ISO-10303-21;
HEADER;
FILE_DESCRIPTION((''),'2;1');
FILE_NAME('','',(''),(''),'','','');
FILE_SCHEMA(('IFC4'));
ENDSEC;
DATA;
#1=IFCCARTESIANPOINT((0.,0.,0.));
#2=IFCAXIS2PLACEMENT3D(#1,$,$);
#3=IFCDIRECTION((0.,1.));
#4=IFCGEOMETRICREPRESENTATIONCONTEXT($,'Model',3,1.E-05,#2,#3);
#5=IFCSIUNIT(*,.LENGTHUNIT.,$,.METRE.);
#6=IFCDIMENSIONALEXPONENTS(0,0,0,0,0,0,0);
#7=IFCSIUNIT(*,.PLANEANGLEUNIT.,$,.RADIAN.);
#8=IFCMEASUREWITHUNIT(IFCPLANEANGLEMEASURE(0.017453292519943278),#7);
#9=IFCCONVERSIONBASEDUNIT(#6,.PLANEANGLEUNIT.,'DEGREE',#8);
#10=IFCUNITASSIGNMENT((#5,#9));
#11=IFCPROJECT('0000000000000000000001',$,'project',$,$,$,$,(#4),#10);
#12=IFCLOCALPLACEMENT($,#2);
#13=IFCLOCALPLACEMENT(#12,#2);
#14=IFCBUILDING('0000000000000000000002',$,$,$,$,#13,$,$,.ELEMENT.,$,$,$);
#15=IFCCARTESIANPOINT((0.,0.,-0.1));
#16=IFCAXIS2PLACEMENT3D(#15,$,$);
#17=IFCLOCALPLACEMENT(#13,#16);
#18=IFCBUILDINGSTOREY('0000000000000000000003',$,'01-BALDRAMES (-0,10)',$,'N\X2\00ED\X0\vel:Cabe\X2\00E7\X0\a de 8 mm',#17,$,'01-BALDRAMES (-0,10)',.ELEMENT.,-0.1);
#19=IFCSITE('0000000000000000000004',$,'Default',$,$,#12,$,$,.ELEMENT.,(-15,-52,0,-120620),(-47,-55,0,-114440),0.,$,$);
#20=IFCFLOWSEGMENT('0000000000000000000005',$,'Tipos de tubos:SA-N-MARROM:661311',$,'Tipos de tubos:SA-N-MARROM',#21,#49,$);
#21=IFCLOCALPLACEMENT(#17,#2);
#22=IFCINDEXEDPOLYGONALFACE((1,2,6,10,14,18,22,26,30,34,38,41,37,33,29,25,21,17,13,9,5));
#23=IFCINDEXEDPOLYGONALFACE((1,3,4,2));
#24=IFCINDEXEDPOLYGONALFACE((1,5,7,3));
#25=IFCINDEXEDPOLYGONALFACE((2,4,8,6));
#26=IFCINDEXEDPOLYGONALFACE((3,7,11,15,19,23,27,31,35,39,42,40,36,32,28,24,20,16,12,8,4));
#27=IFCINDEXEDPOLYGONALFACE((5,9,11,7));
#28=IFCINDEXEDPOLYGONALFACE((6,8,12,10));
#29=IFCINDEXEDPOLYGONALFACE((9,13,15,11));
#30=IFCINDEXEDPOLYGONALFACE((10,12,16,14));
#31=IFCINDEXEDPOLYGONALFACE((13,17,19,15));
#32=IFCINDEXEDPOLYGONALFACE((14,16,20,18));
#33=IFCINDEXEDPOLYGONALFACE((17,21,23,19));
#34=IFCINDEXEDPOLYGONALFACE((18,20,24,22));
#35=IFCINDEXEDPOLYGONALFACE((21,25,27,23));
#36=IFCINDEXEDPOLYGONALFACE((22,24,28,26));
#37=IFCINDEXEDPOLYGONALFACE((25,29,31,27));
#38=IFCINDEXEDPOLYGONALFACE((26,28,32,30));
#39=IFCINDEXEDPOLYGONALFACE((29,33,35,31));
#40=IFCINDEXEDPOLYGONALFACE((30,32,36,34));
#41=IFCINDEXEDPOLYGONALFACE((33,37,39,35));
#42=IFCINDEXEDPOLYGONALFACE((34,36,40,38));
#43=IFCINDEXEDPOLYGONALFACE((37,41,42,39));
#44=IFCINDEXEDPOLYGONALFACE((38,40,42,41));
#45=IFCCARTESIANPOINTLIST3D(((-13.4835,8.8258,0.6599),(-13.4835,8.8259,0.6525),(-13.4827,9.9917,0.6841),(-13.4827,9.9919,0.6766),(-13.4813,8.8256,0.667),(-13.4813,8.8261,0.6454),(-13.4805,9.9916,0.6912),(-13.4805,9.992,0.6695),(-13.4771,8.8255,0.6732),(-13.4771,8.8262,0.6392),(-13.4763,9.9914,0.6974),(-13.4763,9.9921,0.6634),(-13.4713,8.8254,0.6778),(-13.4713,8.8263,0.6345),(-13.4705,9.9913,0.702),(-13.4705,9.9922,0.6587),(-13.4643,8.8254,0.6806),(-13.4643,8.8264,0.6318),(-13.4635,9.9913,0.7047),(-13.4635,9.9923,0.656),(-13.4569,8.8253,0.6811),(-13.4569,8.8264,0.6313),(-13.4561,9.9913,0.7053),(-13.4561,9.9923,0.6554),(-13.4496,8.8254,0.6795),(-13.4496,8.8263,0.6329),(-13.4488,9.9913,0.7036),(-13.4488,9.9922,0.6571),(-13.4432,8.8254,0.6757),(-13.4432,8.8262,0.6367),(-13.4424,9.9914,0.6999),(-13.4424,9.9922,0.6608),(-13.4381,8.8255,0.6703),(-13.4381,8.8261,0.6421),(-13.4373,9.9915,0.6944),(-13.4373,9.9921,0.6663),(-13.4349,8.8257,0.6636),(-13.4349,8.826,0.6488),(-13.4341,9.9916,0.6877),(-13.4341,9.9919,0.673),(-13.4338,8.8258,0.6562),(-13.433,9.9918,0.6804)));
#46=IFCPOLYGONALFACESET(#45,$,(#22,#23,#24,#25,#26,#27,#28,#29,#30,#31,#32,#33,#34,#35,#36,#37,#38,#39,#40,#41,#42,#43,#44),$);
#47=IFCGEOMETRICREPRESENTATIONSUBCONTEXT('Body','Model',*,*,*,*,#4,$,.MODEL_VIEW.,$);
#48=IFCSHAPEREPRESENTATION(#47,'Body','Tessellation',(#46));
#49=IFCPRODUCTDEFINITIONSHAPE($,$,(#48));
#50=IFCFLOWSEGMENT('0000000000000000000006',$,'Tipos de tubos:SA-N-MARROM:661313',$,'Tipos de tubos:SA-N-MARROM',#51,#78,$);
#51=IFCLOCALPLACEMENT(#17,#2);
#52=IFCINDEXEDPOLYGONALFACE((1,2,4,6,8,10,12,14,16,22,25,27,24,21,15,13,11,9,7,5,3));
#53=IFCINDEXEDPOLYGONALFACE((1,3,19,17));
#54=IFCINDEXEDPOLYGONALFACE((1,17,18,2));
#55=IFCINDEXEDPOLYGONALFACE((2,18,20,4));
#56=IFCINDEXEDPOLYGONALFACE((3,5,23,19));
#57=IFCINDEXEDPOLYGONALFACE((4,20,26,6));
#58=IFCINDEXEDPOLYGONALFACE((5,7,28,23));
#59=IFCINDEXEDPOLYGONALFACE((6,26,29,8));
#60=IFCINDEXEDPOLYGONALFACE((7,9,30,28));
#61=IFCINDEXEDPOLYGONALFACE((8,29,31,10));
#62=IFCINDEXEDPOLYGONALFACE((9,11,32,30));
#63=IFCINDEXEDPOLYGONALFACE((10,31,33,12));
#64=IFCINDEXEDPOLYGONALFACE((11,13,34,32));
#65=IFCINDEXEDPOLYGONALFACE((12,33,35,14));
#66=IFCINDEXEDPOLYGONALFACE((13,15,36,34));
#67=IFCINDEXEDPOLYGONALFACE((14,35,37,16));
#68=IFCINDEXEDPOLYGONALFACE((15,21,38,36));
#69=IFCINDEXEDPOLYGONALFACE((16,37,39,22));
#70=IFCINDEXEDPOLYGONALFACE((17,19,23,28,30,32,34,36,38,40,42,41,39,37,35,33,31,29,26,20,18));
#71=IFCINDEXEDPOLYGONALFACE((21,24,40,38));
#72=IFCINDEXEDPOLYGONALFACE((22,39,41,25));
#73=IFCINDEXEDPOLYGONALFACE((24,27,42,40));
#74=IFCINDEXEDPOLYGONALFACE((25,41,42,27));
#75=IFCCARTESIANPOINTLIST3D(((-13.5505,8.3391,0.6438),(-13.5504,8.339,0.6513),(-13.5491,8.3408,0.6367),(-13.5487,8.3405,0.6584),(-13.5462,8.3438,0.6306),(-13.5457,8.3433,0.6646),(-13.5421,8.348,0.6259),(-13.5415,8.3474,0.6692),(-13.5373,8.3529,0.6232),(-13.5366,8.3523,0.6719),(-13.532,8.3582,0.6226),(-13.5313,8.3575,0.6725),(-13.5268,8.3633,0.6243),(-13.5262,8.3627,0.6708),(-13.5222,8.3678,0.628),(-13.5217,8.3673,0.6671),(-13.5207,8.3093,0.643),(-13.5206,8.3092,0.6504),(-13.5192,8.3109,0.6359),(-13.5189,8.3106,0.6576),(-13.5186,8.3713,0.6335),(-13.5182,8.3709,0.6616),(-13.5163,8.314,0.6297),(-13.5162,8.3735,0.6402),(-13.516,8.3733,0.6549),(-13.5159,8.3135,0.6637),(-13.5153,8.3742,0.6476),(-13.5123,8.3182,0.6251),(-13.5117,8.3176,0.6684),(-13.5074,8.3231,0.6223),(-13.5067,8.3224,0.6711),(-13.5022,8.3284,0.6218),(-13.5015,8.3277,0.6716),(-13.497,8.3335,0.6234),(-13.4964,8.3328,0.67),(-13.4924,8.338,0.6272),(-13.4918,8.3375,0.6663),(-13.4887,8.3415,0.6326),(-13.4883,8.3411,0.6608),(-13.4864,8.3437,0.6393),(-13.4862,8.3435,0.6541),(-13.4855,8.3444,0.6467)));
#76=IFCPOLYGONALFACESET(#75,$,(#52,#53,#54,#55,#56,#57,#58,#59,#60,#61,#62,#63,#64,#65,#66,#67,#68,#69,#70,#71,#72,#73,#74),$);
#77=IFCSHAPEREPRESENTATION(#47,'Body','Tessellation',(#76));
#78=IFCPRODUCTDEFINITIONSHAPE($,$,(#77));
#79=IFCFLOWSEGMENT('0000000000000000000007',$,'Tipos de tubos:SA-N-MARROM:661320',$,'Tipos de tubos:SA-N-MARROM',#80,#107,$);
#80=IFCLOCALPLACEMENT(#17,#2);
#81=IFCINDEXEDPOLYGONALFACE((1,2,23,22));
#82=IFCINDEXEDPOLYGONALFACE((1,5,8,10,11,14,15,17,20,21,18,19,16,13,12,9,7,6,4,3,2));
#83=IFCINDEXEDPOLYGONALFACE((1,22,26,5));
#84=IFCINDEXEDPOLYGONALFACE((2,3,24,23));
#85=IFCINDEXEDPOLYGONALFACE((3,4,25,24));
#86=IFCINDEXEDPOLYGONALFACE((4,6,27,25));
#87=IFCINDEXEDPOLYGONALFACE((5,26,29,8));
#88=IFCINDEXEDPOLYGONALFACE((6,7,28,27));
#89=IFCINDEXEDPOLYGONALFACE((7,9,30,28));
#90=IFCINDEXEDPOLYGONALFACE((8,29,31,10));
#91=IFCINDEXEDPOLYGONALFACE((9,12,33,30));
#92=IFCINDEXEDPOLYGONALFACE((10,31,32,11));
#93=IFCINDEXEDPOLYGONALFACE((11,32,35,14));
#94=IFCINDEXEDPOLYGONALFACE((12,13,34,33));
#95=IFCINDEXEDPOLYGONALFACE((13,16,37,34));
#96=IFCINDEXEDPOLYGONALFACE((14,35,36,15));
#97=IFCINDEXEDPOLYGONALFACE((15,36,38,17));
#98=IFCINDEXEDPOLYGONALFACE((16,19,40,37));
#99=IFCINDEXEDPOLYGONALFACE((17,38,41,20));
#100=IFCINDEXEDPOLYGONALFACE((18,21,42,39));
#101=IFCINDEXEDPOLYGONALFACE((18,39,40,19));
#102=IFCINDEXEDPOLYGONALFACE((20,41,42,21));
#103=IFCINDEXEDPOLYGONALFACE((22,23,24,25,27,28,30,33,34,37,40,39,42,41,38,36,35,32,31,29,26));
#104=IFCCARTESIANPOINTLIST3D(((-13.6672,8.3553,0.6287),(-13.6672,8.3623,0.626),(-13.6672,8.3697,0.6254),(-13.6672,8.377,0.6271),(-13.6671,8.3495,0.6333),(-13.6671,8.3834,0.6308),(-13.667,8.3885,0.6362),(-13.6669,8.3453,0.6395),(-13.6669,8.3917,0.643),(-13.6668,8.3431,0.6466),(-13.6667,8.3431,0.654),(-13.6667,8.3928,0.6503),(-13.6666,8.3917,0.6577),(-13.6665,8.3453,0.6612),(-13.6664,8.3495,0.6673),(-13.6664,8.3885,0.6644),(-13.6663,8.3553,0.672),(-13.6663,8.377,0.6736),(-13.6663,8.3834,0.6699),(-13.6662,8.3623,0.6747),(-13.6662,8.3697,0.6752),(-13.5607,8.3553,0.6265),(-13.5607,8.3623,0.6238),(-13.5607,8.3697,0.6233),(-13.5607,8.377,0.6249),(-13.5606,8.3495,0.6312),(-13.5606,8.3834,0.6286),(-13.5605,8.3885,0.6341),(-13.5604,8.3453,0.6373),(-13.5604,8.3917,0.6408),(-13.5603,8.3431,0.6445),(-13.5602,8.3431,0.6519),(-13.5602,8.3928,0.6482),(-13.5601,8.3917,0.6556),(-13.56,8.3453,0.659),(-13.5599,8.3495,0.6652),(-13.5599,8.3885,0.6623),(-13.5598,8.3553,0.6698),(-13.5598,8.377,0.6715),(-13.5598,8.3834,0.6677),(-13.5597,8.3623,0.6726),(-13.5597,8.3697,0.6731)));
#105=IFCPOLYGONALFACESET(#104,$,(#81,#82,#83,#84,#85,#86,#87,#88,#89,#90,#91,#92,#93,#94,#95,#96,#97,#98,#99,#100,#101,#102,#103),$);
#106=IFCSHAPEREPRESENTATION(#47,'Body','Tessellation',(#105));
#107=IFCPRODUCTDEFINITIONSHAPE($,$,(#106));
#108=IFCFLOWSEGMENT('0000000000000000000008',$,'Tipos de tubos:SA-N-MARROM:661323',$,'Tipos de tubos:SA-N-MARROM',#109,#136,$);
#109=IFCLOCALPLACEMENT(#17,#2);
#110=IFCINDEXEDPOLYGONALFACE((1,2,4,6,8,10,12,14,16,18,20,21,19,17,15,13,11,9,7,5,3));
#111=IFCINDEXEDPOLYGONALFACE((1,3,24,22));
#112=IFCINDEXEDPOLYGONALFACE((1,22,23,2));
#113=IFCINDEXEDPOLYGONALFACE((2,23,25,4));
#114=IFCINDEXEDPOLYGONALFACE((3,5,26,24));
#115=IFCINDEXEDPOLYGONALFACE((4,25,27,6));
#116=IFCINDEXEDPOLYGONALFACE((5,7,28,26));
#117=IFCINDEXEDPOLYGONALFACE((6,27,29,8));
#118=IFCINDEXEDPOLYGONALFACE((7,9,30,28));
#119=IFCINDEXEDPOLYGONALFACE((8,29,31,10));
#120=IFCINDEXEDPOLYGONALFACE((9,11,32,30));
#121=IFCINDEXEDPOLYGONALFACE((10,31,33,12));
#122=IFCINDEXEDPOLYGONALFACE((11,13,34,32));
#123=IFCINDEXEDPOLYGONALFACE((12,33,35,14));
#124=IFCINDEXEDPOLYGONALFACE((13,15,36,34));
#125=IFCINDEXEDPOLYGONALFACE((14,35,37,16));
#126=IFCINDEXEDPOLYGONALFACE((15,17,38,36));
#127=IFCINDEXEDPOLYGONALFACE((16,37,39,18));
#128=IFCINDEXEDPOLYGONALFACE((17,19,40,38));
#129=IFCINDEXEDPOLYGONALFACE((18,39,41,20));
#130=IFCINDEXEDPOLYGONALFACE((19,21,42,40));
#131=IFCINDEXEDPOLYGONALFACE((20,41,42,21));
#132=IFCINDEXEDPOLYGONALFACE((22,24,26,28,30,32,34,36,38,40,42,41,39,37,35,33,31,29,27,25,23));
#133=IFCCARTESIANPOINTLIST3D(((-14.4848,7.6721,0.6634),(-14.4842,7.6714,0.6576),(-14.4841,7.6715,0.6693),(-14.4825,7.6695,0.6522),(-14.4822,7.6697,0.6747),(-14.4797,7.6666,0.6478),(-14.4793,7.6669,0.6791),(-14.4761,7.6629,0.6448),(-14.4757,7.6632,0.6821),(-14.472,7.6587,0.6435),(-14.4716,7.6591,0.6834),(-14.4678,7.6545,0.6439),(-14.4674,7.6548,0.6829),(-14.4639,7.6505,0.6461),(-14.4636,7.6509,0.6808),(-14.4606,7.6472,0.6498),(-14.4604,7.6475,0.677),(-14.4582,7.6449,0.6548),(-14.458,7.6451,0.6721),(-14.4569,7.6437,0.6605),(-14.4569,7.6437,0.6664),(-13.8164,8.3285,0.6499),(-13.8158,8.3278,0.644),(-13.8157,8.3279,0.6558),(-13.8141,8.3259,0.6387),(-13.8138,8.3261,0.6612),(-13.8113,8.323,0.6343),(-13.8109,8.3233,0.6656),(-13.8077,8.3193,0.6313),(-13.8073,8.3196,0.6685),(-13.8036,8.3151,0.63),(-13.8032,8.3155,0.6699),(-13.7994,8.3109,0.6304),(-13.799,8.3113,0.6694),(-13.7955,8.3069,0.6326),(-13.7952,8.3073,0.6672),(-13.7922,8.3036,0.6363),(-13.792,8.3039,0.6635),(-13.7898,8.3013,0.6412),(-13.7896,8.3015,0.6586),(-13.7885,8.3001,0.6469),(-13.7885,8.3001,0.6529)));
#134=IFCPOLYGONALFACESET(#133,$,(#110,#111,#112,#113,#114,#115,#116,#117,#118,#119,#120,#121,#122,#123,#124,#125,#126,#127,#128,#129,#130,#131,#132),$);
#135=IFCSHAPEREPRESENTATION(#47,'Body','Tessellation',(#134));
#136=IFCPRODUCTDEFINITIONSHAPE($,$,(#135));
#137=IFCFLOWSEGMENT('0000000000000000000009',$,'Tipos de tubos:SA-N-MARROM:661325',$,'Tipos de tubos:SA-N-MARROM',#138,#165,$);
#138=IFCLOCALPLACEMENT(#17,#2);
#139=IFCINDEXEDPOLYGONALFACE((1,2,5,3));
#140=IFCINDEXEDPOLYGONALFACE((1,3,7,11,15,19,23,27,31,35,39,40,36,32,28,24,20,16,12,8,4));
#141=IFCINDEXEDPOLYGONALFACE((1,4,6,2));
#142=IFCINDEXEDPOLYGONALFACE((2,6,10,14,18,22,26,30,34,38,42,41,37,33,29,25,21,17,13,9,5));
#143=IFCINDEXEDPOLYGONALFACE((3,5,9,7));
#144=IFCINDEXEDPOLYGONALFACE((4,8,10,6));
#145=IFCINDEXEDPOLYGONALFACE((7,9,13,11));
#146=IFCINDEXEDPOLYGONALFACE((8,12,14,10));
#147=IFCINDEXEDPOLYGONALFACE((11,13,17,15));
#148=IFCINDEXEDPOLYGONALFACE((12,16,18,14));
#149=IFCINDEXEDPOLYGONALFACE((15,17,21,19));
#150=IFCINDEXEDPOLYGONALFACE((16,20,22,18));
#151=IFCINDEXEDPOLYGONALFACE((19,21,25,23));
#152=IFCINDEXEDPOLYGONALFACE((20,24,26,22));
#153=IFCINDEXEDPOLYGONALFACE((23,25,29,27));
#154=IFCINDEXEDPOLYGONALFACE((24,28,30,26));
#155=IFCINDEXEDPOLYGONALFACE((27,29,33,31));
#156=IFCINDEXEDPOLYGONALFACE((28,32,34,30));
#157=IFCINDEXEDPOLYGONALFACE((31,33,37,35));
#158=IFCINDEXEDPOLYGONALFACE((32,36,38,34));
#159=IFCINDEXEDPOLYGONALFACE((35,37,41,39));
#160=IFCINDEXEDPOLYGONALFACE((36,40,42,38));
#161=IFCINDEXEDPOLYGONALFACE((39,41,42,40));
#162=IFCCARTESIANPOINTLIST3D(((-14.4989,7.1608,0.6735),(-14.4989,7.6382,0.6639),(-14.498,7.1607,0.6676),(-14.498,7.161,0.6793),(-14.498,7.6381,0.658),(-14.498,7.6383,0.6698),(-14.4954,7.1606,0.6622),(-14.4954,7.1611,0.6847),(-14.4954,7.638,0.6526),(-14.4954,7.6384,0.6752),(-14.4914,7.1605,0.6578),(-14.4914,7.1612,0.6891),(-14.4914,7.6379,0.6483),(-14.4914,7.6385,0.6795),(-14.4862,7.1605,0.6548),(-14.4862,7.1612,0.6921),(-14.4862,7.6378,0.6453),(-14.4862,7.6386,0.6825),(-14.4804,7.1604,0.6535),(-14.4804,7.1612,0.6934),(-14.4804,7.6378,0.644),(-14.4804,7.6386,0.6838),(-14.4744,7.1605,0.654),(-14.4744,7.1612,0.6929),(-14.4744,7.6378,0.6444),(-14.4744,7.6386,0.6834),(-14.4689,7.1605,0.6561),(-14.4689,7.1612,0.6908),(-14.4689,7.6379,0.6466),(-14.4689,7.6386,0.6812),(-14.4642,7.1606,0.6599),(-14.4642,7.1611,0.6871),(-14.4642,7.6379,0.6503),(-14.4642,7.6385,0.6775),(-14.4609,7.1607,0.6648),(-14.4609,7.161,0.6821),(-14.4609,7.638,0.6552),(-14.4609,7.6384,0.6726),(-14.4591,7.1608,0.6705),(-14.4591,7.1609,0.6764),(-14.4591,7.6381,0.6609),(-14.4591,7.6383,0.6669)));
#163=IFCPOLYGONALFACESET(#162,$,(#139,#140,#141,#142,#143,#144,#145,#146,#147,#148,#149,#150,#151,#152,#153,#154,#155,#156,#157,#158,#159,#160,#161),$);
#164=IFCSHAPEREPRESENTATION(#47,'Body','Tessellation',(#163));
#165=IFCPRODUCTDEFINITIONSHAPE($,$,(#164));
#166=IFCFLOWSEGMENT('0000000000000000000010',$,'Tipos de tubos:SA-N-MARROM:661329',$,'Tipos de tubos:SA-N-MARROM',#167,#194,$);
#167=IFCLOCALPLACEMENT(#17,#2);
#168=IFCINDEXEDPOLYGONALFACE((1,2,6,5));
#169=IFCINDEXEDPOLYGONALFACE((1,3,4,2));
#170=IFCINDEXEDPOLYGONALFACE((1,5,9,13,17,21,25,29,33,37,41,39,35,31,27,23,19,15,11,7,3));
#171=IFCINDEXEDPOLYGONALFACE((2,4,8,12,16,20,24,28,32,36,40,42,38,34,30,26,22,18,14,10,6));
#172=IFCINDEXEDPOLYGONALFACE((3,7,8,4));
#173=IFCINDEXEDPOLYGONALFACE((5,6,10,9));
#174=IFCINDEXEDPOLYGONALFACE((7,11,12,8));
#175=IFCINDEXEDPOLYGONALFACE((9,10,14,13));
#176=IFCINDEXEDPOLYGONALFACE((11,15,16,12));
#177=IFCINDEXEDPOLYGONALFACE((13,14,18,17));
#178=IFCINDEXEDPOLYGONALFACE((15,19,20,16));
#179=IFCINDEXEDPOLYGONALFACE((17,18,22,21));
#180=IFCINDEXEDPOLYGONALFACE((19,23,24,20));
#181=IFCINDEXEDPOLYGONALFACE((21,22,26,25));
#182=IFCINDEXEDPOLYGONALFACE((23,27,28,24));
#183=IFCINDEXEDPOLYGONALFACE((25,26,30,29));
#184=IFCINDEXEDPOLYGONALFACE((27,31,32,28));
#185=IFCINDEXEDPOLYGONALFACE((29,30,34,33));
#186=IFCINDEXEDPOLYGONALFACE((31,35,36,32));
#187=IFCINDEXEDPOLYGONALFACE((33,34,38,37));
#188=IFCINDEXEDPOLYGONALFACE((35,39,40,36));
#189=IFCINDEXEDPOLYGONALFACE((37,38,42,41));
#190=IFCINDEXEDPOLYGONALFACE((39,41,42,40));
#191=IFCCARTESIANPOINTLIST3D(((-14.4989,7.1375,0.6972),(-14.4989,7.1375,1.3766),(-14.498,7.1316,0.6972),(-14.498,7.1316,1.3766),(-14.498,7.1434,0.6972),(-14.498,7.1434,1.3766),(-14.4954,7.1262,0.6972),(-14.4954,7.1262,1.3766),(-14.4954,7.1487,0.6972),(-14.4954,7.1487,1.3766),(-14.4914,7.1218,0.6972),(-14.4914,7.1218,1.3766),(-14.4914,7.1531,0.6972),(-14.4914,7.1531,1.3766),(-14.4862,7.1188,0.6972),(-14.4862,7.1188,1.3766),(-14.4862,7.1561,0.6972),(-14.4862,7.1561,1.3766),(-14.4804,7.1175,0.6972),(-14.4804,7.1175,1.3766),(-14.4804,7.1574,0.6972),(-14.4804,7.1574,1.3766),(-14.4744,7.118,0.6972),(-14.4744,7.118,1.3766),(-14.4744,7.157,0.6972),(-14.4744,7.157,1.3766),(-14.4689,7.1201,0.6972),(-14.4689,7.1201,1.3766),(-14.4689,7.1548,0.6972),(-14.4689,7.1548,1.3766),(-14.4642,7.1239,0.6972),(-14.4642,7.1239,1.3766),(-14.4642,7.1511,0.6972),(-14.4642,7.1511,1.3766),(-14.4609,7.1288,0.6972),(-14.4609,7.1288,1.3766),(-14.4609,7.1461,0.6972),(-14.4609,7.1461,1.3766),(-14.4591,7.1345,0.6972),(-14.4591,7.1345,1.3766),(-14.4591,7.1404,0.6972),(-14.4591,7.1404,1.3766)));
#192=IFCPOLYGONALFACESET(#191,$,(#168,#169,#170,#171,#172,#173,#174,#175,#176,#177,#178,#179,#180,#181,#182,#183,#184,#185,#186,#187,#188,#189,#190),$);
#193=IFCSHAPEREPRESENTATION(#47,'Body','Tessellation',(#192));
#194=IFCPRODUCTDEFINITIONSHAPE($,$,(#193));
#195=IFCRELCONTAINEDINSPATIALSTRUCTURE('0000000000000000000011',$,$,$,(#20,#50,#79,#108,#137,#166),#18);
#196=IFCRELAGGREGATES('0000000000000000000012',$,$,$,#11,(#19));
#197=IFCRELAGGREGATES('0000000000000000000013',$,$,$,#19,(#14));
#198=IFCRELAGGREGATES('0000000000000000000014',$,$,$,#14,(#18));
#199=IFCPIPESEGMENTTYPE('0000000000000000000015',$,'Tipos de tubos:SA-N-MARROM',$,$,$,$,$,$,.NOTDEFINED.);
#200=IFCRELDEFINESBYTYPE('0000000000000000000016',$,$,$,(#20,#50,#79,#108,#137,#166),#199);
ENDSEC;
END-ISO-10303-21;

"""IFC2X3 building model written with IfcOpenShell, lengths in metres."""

from ifc_helpers import new_model, entity, si_unit, converted_unit, direction, frame, frame_2d, origin, origin_2d_with_axis, place, context, subcontext, project, spatial, circle, extrude, type_object, element, save


model = new_model("IFC2X3")

# Units and contexts
model_context = context("Model", 3, precision=1e-05, world=origin(), true_north=direction((0.0, 1.0)))
body_context = subcontext(model_context, "Body", "Model", "MODEL_VIEW")
ifc_project = project(units=[si_unit("LENGTHUNIT", "METRE"), converted_unit("PLANEANGLEUNIT", "DEGREE", entity("IfcPlaneAngleMeasure", 0.017453292519943278), si_unit("PLANEANGLEUNIT", "RADIAN"), dimensions=[0, 0, 0, 0, 0, 0, 0])], contexts=[model_context])

# Site, building, storey
site_placement = place(None, origin())
site = spatial("IfcSite", under=ifc_project, at=site_placement, Name="Default", CompositionType="ELEMENT", RefLatitude=(-15, -52, 0, -120620), RefLongitude=(-47, -55, 0, -114440), RefElevation=0.0)
building_placement = place(site_placement, origin())
building = spatial("IfcBuilding", under=site, at=building_placement, CompositionType="ELEMENT")
storey_placement = place(building_placement, frame((0.0, 0.0, -0.1)))
storey = spatial("IfcBuildingStorey", under=building, at=storey_placement, Name="01-BALDRAMES (-0,10)", ObjectType="Nível:Cabeça de 8 mm", LongName="01-BALDRAMES (-0,10)", CompositionType="ELEMENT", Elevation=-0.1)

# Flow segments
pipe_segment_type_1 = type_object("IfcPipeSegmentType", Name="Tipos de tubos:SA-N-MARROM", PredefinedType="NOTDEFINED")
flow_segment_1_placement = place(storey_placement, origin())
element("IfcFlowSegment", 1, at=flow_segment_1_placement, inside=storey, type_object=pipe_segment_type_1, Name="Tipos de tubos:SA-N-MARROM:661311", ObjectType="Tipos de tubos:SA-N-MARROM", context=body_context, shape_type="SweptSolid", body=[
    extrude(circle(Radius=0.025, at=origin_2d_with_axis()), frame((-13.4588, 8.8259, 0.6562), z_axis=(0.000685, 0.999785, 0.020718), x_axis=(1.0, -0.000685, 0.0)), (0.0, 0.0, 1.0), 1.1662),
])
flow_segment_2_placement = place(storey_placement, origin())
element("IfcFlowSegment", 2, at=flow_segment_2_placement, inside=storey, type_object=pipe_segment_type_1, Name="Tipos de tubos:SA-N-MARROM:661313", ObjectType="Tipos de tubos:SA-N-MARROM", context=body_context, shape_type="SweptSolid", body=[
    extrude(circle(Radius=0.025, at=frame_2d((0.0, 0.0), x_axis=(1.0, 0.0))), frame((-13.5031, 8.3267, 0.6467), z_axis=(-0.706966, 0.706965, 0.019996), x_axis=(0.707106, 0.707107, 0.0)), (0.0, 0.0, 1.0), 0.0422),
])
flow_segment_3_placement = place(storey_placement, origin())
element("IfcFlowSegment", 3, at=flow_segment_3_placement, inside=storey, type_object=pipe_segment_type_1, Name="Tipos de tubos:SA-N-MARROM:661320", ObjectType="Tipos de tubos:SA-N-MARROM", context=body_context, shape_type="SweptSolid", body=[
    extrude(circle(Radius=0.025, at=frame_2d((0.0, 0.0), x_axis=(1.0, 0.0))), frame((-13.5602, 8.3678, 0.6482), z_axis=(-0.9998, -0.000001, 0.019996), x_axis=(-0.000001, 1.0, 0.0)), (0.0, 0.0, 1.0), 0.1065),
])
flow_segment_4_placement = place(storey_placement, origin())
element("IfcFlowSegment", 4, at=flow_segment_4_placement, inside=storey, type_object=pipe_segment_type_1, Name="Tipos de tubos:SA-N-MARROM:661323", ObjectType="Tipos de tubos:SA-N-MARROM", context=body_context, shape_type="SweptSolid", body=[
    extrude(circle(Radius=0.02, at=frame_2d((0.0, 0.0), x_axis=(1.0, 0.0))), frame((-13.8024, 8.3142, 0.6499), z_axis=(-0.713408, -0.700601, 0.014439), x_axis=(-0.700674, 0.713482, 0.0)), (0.0, 0.0, 1.0), 0.9369),
])
flow_segment_5_placement = place(storey_placement, origin())
element("IfcFlowSegment", 5, at=flow_segment_5_placement, inside=storey, type_object=pipe_segment_type_1, Name="Tipos de tubos:SA-N-MARROM:661325", ObjectType="Tipos de tubos:SA-N-MARROM", context=body_context, shape_type="SweptSolid", body=[
    extrude(circle(Radius=0.02, at=frame_2d((0.0, 0.0), x_axis=(1.0, 0.0))), frame((-14.4789, 7.6382, 0.6639), z_axis=(0.000001, -0.9998, 0.019996), x_axis=(-1.0, -0.000001, 0.0)), (0.0, 0.0, 1.0), 0.4775),
])
flow_segment_6_placement = place(storey_placement, origin())
element("IfcFlowSegment", 6, at=flow_segment_6_placement, inside=storey, type_object=pipe_segment_type_1, Name="Tipos de tubos:SA-N-MARROM:661329", ObjectType="Tipos de tubos:SA-N-MARROM", context=body_context, shape_type="SweptSolid", body=[
    extrude(circle(Radius=0.02, at=origin_2d_with_axis()), frame((-14.4789, 7.1375, 0.6972), z_axis=(0.0, 0.0, 1.0), x_axis=(-1.0, 0.0, 0.0)), (0.0, 0.0, 1.0), 0.6794),
])

save(model, "model.ifc")
